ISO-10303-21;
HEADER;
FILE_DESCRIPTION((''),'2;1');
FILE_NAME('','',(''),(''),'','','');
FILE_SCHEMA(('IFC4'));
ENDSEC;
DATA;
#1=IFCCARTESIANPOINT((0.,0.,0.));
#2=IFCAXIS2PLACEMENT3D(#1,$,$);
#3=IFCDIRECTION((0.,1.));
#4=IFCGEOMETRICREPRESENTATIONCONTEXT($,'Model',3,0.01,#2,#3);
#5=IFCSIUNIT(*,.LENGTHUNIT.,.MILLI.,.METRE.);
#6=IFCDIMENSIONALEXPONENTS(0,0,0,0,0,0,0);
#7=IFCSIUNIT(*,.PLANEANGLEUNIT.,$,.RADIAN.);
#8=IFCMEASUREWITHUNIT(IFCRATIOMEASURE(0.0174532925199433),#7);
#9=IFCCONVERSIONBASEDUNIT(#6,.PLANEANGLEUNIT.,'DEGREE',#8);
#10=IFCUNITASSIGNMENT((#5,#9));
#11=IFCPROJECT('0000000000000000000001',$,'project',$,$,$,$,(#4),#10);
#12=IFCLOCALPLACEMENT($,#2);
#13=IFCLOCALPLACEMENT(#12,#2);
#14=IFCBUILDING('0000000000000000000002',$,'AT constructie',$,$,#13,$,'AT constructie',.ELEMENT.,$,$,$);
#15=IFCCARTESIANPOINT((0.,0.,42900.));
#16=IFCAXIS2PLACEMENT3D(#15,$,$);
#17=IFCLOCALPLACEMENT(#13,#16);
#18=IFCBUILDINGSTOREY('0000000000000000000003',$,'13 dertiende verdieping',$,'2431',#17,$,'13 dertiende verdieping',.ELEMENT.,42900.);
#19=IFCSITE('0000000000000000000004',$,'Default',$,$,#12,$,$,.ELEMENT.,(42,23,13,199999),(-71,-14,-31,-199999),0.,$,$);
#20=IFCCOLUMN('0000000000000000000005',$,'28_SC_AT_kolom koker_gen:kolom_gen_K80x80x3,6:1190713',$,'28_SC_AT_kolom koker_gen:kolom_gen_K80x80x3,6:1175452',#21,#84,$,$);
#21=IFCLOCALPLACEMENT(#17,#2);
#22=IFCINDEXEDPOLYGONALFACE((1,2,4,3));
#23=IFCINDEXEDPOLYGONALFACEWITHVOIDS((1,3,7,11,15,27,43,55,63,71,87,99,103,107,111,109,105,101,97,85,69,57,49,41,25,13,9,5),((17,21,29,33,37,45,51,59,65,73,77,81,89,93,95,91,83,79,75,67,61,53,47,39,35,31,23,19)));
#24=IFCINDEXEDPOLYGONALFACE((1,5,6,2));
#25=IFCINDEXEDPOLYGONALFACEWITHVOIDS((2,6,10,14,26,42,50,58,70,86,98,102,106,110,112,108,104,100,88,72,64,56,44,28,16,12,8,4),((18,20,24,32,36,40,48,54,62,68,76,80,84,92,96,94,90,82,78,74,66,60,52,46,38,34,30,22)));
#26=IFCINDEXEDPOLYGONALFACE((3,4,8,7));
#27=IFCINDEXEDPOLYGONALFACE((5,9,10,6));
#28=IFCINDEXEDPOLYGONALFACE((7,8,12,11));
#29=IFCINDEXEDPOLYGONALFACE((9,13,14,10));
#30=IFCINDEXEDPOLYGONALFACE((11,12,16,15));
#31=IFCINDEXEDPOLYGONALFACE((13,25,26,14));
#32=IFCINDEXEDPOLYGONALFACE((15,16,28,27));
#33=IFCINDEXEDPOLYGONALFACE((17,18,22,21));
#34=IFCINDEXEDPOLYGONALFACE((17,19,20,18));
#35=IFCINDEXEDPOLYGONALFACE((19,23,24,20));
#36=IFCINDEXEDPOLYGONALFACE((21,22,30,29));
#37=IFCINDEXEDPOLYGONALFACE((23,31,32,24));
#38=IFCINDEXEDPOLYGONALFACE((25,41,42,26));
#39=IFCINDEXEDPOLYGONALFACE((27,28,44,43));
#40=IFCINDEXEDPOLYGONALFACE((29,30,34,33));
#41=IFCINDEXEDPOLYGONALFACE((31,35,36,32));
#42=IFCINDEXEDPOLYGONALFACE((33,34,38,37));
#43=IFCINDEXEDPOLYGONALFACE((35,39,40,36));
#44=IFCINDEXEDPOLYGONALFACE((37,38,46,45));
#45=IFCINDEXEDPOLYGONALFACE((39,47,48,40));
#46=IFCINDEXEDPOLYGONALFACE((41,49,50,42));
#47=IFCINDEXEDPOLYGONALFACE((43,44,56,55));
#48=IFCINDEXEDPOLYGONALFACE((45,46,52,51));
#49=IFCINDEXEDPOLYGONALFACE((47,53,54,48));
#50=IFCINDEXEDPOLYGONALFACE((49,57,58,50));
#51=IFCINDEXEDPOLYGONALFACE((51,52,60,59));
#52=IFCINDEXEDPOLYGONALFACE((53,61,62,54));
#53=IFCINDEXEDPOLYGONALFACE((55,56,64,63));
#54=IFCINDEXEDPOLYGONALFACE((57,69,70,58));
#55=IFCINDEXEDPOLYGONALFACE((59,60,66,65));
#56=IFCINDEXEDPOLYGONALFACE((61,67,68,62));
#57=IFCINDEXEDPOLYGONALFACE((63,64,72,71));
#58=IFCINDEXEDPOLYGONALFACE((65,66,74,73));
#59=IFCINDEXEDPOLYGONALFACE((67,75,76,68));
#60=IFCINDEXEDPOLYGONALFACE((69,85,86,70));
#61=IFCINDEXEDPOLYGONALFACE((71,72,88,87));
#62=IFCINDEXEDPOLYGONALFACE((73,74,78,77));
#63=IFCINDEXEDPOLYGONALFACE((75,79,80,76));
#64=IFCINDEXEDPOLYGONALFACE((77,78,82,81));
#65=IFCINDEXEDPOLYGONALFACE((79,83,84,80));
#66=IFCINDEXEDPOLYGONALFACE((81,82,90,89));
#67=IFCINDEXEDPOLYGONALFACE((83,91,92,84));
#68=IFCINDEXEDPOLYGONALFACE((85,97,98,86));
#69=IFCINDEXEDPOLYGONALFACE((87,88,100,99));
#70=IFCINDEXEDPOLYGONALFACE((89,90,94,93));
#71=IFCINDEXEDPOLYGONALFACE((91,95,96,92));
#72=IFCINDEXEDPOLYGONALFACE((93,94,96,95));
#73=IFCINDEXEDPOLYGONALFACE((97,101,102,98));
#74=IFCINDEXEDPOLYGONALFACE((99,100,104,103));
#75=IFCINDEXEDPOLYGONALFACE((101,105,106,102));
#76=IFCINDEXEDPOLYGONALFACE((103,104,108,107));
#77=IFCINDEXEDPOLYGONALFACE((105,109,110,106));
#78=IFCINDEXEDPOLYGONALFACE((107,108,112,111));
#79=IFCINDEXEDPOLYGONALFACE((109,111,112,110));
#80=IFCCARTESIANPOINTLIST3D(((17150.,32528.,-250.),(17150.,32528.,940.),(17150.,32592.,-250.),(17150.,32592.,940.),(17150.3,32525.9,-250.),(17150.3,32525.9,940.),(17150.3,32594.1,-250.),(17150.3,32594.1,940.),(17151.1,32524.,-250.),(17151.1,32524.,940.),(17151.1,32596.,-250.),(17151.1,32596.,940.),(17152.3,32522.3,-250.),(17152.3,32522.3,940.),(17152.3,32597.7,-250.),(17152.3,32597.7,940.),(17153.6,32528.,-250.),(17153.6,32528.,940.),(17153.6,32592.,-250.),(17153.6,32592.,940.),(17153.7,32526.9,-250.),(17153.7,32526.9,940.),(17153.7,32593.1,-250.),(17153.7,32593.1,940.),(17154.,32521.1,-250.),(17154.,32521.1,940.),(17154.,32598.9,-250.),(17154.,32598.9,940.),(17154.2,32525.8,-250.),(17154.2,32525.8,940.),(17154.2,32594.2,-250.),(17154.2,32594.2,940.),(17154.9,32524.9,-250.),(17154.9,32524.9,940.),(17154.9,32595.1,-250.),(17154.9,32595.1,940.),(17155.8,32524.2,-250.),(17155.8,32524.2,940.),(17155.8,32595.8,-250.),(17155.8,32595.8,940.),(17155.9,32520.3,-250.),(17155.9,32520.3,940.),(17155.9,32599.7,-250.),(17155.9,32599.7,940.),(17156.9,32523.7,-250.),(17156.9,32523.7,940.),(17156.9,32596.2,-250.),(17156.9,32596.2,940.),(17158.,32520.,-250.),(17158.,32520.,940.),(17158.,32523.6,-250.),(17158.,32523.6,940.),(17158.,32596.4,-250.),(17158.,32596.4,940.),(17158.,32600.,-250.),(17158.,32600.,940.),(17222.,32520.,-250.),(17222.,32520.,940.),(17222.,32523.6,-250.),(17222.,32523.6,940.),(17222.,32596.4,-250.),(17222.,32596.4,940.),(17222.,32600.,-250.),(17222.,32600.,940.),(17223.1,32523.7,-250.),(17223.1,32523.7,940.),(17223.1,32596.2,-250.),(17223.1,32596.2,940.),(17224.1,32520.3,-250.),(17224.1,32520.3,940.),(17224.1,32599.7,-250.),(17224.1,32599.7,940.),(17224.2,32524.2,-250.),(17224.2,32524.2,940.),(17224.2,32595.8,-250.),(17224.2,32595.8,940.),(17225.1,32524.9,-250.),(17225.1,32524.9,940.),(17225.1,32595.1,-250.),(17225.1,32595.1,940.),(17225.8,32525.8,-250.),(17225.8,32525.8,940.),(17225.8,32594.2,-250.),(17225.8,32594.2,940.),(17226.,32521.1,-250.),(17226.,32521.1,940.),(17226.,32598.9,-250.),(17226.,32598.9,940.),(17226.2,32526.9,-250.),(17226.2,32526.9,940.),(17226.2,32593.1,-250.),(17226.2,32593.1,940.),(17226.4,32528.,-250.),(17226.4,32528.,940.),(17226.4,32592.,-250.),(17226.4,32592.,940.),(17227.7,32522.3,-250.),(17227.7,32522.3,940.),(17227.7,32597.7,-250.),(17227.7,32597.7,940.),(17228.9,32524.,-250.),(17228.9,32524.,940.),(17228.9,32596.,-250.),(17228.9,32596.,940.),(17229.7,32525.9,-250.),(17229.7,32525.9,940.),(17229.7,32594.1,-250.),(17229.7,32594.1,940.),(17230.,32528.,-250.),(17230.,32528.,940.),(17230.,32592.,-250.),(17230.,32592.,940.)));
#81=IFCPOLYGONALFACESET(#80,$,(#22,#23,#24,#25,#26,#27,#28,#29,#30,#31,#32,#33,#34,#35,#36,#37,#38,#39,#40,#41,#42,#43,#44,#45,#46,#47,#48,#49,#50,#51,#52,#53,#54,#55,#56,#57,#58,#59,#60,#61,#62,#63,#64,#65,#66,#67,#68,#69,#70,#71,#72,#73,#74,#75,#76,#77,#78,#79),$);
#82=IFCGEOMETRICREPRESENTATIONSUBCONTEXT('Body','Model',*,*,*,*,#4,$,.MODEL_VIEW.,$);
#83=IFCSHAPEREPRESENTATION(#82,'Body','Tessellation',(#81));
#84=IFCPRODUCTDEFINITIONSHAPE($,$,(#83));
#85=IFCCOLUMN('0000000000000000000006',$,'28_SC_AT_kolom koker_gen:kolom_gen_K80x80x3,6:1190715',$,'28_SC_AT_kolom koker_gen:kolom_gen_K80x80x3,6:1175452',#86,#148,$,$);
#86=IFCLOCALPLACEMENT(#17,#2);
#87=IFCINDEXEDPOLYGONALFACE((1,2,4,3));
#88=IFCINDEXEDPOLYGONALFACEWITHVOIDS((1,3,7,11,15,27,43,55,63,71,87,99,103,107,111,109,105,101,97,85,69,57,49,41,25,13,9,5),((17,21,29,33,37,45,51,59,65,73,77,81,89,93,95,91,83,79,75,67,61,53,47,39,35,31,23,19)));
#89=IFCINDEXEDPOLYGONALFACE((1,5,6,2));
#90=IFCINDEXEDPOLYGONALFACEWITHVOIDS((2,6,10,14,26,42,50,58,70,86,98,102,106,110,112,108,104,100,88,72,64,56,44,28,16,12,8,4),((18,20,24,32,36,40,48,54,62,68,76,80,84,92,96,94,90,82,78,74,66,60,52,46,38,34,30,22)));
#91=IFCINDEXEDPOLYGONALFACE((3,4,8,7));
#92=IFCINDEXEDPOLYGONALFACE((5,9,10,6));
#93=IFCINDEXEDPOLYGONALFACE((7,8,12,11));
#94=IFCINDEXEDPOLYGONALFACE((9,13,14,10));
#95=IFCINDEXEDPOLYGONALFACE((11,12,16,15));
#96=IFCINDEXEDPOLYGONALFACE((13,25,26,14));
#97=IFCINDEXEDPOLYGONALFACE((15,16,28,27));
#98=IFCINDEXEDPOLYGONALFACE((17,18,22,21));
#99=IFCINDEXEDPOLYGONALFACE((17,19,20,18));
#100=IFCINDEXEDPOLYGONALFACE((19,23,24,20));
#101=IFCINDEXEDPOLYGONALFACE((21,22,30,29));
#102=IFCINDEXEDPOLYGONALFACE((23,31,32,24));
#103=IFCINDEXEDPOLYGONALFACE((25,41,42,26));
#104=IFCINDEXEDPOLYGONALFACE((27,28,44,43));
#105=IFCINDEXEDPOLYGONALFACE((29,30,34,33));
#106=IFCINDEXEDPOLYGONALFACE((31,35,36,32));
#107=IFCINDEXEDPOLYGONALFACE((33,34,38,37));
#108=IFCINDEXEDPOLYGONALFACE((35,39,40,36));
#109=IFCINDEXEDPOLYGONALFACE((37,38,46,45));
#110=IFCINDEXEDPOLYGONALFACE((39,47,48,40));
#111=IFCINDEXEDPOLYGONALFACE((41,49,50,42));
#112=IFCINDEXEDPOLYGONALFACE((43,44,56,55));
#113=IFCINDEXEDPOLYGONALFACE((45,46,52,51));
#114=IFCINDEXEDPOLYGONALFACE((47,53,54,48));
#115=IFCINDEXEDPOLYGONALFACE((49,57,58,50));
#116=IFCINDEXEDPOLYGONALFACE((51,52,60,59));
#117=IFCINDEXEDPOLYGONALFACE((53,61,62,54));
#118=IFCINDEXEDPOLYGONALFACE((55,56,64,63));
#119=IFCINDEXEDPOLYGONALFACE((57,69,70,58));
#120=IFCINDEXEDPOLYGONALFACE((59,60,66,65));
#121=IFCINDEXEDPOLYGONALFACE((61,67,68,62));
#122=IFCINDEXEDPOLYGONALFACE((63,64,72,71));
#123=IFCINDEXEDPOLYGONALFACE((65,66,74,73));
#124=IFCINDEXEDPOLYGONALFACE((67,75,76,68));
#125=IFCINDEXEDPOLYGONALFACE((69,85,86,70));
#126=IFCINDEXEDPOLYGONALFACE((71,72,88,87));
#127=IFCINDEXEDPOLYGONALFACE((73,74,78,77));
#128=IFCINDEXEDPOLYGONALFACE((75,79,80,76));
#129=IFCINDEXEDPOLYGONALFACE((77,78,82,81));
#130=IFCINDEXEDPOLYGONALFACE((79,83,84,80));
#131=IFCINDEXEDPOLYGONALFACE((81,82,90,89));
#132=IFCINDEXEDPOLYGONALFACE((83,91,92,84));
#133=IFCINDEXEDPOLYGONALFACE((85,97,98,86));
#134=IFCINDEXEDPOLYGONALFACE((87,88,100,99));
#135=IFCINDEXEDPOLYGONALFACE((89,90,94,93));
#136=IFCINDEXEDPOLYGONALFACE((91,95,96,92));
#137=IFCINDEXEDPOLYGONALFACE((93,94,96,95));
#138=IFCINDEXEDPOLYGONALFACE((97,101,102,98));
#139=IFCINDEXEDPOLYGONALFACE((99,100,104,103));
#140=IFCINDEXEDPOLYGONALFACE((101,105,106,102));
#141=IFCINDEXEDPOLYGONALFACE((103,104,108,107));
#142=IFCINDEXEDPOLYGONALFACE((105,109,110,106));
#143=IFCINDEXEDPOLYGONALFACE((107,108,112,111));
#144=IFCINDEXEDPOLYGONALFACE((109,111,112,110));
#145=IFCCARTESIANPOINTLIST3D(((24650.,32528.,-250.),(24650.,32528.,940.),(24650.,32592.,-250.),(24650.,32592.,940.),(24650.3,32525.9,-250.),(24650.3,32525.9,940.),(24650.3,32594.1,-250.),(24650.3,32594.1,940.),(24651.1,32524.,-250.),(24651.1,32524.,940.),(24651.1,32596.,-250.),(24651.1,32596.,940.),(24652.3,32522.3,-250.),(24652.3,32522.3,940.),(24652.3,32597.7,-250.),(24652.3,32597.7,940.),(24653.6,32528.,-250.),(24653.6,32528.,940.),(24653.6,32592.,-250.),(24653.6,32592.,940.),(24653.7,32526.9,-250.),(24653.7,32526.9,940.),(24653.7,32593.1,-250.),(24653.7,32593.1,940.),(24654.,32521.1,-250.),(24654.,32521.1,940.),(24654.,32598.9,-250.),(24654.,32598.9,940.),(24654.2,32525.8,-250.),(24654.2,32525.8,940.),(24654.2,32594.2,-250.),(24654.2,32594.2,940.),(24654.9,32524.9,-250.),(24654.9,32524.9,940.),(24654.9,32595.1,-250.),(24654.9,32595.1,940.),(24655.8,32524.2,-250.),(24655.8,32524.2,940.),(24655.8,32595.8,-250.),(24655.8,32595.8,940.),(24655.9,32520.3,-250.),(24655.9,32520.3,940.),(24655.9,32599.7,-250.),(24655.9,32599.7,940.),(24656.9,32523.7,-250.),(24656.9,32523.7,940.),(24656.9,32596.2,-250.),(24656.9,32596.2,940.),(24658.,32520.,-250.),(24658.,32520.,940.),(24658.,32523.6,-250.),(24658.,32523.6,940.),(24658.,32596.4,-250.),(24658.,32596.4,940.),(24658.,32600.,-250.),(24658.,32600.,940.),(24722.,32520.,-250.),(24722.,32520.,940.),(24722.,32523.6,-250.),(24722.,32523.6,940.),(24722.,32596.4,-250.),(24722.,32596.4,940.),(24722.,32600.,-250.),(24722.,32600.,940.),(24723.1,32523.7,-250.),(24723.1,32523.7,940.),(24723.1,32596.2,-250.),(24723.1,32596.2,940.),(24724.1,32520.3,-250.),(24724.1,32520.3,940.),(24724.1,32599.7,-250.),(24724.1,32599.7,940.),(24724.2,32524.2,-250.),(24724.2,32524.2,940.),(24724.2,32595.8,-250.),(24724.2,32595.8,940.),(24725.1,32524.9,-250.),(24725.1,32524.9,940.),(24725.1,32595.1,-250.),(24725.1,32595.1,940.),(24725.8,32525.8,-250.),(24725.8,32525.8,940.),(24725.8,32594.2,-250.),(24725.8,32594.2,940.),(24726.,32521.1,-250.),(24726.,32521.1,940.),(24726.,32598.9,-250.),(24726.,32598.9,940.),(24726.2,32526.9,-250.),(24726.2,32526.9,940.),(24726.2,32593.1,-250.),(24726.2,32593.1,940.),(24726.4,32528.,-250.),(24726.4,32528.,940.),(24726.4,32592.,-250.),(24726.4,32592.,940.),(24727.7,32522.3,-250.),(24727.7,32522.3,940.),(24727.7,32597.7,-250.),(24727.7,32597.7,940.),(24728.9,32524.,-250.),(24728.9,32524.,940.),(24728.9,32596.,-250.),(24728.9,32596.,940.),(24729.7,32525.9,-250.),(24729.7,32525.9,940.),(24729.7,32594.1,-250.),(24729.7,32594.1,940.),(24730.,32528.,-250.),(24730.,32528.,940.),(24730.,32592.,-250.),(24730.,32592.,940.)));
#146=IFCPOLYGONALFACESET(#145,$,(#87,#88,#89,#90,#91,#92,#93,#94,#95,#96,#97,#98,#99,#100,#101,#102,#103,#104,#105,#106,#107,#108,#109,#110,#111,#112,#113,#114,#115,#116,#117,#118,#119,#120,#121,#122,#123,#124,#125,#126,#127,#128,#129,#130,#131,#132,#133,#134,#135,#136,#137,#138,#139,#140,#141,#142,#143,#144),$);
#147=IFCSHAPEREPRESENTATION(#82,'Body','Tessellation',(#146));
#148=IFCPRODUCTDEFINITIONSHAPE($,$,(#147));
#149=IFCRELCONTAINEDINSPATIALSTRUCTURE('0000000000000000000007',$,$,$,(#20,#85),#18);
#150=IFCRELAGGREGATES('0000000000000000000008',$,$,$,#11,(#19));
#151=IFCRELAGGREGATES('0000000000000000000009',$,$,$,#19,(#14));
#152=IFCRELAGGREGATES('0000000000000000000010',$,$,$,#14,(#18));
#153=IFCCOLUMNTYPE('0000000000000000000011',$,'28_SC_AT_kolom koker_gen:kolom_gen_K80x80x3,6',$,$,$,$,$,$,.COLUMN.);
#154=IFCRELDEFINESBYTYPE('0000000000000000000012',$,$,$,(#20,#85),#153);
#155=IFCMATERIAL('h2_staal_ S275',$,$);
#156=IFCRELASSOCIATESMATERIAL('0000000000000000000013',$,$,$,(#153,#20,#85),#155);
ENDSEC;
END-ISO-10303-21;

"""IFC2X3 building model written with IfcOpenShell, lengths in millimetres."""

from ifc_helpers import new_model, entity, si_unit, converted_unit, direction, frame, frame_2d, origin, place, context, subcontext, project, spatial, polyline, circle_curve, parameter, trimmed, segment, composite_curve, outline, extrude, source, transform, mapped, material, type_object, type_shapes, element, save


model = new_model("IFC2X3")

# Units and contexts
model_context = context("Model", 3, precision=0.01, world=origin(), true_north=direction((0.0, 1.0)))
body_context = subcontext(model_context, "Body", "Model", "MODEL_VIEW")
ifc_project = project(units=[si_unit("LENGTHUNIT", "METRE", prefix="MILLI"), converted_unit("PLANEANGLEUNIT", "DEGREE", entity("IfcRatioMeasure", 0.0174532925199433), si_unit("PLANEANGLEUNIT", "RADIAN"), dimensions=[0, 0, 0, 0, 0, 0, 0])], contexts=[model_context])

# Site, building, storey
site_placement = place(None, origin())
site = spatial("IfcSite", under=ifc_project, at=site_placement, Name="Default", CompositionType="ELEMENT", RefLatitude=(42, 23, 13, 199999), RefLongitude=(-71, -14, -31, -199999), RefElevation=0.0)
building_placement = place(site_placement, origin())
building = spatial("IfcBuilding", under=site, at=building_placement, Name="AT constructie", LongName="AT constructie", CompositionType="ELEMENT")
storey_placement = place(building_placement, frame((0.0, 0.0, 42900.0)))
storey = spatial("IfcBuildingStorey", under=building, at=storey_placement, Name="13 dertiende verdieping", ObjectType="2431", LongName="13 dertiende verdieping", CompositionType="ELEMENT", Elevation=42900.0)

# Columns
ifc_material = material(Name="h2_staal_ S275")
column_type_1 = type_object("IfcColumnType", Name="28_SC_AT_kolom koker_gen:kolom_gen_K80x80x3,6", PredefinedType="COLUMN", material=ifc_material)
shared_shape_1 = source(origin(), body_context, "Body", "SweptSolid", [
    extrude(outline(composite_curve([segment(trimmed(circle_curve(frame_2d((32.0, 32.0), x_axis=(1.0, 0.0)), 8.0), [parameter(360.0)], [parameter(90.0)], True, "PARAMETER"), True, "CONTINUOUS"), segment(polyline([(32.0, 40.0), (-32.0, 40.0)]), True, "CONTINUOUS"), segment(trimmed(circle_curve(frame_2d((-32.0, 32.0), x_axis=(1.0, 0.0)), 8.0), [parameter(90.0)], [parameter(180.0)], True, "PARAMETER"), True, "CONTINUOUS"), segment(polyline([(-40.0, 32.0), (-40.0, -32.0)]), True, "CONTINUOUS"), segment(trimmed(circle_curve(frame_2d((-32.0, -32.0), x_axis=(1.0, 0.0)), 8.0), [parameter(180.0)], [parameter(270.0)], True, "PARAMETER"), True, "CONTINUOUS"), segment(polyline([(-32.0, -40.0), (32.0, -40.0)]), True, "CONTINUOUS"), segment(trimmed(circle_curve(frame_2d((32.0, -32.0), x_axis=(1.0, 0.0)), 8.0), [parameter(270.0)], [parameter(0.0)], True, "PARAMETER"), True, "CONTINUOUS"), segment(polyline([(40.0, -32.0), (40.0, 32.0)]), True, "CONTINUOUS")], self_intersect=False), holes=[composite_curve([segment(polyline([(-32.0, 36.4), (32.0, 36.4)]), True, "CONTINUOUS"), segment(trimmed(circle_curve(frame_2d((32.0, 32.0), x_axis=(1.0, 0.0)), 4.4), [parameter(360.0)], [parameter(90.0)], True, "PARAMETER"), False, "CONTINUOUS"), segment(polyline([(36.4, 32.0), (36.4, -32.0)]), True, "CONTINUOUS"), segment(trimmed(circle_curve(frame_2d((32.0, -32.0), x_axis=(1.0, 0.0)), 4.4), [parameter(270.0)], [parameter(360.0)], True, "PARAMETER"), False, "CONTINUOUS"), segment(polyline([(32.0, -36.4), (-32.0, -36.4)]), True, "CONTINUOUS"), segment(trimmed(circle_curve(frame_2d((-32.0, -32.0), x_axis=(1.0, 0.0)), 4.4), [parameter(180.0)], [parameter(270.0)], True, "PARAMETER"), False, "CONTINUOUS"), segment(polyline([(-36.4, -32.0), (-36.4, 32.0)]), True, "CONTINUOUS"), segment(trimmed(circle_curve(frame_2d((-32.0, 32.0), x_axis=(1.0, 0.0)), 4.4), [parameter(90.0)], [parameter(180.0)], True, "PARAMETER"), False, "CONTINUOUS")], self_intersect=False)]), frame((0.0, 0.0, 42650.0), z_axis=(0.0, 0.0, 1.0), x_axis=(-1.0, 0.0, 0.0)), (0.0, 0.0, 1.0), 1190.0),
])
type_shapes(column_type_1, [shared_shape_1])
for number, where, name in (
    (1, (17190.0, 32560.0, -42900.0), "28_SC_AT_kolom koker_gen:kolom_gen_K80x80x3,6:1190713"),
    (2, (24690.0, 32560.0, -42900.0), "28_SC_AT_kolom koker_gen:kolom_gen_K80x80x3,6:1190715"),
):
    element("IfcColumn", number, at=place(storey_placement, frame(where)), inside=storey, type_object=column_type_1, material=ifc_material, Name=name, ObjectType="28_SC_AT_kolom koker_gen:kolom_gen_K80x80x3,6:1175452", context=body_context, shape_type="MappedRepresentation", body=[
        mapped(shared_shape_1, transform((0.0, 0.0, 0.0), scale=1.0)),
    ])

save(model, "model.ifc")
